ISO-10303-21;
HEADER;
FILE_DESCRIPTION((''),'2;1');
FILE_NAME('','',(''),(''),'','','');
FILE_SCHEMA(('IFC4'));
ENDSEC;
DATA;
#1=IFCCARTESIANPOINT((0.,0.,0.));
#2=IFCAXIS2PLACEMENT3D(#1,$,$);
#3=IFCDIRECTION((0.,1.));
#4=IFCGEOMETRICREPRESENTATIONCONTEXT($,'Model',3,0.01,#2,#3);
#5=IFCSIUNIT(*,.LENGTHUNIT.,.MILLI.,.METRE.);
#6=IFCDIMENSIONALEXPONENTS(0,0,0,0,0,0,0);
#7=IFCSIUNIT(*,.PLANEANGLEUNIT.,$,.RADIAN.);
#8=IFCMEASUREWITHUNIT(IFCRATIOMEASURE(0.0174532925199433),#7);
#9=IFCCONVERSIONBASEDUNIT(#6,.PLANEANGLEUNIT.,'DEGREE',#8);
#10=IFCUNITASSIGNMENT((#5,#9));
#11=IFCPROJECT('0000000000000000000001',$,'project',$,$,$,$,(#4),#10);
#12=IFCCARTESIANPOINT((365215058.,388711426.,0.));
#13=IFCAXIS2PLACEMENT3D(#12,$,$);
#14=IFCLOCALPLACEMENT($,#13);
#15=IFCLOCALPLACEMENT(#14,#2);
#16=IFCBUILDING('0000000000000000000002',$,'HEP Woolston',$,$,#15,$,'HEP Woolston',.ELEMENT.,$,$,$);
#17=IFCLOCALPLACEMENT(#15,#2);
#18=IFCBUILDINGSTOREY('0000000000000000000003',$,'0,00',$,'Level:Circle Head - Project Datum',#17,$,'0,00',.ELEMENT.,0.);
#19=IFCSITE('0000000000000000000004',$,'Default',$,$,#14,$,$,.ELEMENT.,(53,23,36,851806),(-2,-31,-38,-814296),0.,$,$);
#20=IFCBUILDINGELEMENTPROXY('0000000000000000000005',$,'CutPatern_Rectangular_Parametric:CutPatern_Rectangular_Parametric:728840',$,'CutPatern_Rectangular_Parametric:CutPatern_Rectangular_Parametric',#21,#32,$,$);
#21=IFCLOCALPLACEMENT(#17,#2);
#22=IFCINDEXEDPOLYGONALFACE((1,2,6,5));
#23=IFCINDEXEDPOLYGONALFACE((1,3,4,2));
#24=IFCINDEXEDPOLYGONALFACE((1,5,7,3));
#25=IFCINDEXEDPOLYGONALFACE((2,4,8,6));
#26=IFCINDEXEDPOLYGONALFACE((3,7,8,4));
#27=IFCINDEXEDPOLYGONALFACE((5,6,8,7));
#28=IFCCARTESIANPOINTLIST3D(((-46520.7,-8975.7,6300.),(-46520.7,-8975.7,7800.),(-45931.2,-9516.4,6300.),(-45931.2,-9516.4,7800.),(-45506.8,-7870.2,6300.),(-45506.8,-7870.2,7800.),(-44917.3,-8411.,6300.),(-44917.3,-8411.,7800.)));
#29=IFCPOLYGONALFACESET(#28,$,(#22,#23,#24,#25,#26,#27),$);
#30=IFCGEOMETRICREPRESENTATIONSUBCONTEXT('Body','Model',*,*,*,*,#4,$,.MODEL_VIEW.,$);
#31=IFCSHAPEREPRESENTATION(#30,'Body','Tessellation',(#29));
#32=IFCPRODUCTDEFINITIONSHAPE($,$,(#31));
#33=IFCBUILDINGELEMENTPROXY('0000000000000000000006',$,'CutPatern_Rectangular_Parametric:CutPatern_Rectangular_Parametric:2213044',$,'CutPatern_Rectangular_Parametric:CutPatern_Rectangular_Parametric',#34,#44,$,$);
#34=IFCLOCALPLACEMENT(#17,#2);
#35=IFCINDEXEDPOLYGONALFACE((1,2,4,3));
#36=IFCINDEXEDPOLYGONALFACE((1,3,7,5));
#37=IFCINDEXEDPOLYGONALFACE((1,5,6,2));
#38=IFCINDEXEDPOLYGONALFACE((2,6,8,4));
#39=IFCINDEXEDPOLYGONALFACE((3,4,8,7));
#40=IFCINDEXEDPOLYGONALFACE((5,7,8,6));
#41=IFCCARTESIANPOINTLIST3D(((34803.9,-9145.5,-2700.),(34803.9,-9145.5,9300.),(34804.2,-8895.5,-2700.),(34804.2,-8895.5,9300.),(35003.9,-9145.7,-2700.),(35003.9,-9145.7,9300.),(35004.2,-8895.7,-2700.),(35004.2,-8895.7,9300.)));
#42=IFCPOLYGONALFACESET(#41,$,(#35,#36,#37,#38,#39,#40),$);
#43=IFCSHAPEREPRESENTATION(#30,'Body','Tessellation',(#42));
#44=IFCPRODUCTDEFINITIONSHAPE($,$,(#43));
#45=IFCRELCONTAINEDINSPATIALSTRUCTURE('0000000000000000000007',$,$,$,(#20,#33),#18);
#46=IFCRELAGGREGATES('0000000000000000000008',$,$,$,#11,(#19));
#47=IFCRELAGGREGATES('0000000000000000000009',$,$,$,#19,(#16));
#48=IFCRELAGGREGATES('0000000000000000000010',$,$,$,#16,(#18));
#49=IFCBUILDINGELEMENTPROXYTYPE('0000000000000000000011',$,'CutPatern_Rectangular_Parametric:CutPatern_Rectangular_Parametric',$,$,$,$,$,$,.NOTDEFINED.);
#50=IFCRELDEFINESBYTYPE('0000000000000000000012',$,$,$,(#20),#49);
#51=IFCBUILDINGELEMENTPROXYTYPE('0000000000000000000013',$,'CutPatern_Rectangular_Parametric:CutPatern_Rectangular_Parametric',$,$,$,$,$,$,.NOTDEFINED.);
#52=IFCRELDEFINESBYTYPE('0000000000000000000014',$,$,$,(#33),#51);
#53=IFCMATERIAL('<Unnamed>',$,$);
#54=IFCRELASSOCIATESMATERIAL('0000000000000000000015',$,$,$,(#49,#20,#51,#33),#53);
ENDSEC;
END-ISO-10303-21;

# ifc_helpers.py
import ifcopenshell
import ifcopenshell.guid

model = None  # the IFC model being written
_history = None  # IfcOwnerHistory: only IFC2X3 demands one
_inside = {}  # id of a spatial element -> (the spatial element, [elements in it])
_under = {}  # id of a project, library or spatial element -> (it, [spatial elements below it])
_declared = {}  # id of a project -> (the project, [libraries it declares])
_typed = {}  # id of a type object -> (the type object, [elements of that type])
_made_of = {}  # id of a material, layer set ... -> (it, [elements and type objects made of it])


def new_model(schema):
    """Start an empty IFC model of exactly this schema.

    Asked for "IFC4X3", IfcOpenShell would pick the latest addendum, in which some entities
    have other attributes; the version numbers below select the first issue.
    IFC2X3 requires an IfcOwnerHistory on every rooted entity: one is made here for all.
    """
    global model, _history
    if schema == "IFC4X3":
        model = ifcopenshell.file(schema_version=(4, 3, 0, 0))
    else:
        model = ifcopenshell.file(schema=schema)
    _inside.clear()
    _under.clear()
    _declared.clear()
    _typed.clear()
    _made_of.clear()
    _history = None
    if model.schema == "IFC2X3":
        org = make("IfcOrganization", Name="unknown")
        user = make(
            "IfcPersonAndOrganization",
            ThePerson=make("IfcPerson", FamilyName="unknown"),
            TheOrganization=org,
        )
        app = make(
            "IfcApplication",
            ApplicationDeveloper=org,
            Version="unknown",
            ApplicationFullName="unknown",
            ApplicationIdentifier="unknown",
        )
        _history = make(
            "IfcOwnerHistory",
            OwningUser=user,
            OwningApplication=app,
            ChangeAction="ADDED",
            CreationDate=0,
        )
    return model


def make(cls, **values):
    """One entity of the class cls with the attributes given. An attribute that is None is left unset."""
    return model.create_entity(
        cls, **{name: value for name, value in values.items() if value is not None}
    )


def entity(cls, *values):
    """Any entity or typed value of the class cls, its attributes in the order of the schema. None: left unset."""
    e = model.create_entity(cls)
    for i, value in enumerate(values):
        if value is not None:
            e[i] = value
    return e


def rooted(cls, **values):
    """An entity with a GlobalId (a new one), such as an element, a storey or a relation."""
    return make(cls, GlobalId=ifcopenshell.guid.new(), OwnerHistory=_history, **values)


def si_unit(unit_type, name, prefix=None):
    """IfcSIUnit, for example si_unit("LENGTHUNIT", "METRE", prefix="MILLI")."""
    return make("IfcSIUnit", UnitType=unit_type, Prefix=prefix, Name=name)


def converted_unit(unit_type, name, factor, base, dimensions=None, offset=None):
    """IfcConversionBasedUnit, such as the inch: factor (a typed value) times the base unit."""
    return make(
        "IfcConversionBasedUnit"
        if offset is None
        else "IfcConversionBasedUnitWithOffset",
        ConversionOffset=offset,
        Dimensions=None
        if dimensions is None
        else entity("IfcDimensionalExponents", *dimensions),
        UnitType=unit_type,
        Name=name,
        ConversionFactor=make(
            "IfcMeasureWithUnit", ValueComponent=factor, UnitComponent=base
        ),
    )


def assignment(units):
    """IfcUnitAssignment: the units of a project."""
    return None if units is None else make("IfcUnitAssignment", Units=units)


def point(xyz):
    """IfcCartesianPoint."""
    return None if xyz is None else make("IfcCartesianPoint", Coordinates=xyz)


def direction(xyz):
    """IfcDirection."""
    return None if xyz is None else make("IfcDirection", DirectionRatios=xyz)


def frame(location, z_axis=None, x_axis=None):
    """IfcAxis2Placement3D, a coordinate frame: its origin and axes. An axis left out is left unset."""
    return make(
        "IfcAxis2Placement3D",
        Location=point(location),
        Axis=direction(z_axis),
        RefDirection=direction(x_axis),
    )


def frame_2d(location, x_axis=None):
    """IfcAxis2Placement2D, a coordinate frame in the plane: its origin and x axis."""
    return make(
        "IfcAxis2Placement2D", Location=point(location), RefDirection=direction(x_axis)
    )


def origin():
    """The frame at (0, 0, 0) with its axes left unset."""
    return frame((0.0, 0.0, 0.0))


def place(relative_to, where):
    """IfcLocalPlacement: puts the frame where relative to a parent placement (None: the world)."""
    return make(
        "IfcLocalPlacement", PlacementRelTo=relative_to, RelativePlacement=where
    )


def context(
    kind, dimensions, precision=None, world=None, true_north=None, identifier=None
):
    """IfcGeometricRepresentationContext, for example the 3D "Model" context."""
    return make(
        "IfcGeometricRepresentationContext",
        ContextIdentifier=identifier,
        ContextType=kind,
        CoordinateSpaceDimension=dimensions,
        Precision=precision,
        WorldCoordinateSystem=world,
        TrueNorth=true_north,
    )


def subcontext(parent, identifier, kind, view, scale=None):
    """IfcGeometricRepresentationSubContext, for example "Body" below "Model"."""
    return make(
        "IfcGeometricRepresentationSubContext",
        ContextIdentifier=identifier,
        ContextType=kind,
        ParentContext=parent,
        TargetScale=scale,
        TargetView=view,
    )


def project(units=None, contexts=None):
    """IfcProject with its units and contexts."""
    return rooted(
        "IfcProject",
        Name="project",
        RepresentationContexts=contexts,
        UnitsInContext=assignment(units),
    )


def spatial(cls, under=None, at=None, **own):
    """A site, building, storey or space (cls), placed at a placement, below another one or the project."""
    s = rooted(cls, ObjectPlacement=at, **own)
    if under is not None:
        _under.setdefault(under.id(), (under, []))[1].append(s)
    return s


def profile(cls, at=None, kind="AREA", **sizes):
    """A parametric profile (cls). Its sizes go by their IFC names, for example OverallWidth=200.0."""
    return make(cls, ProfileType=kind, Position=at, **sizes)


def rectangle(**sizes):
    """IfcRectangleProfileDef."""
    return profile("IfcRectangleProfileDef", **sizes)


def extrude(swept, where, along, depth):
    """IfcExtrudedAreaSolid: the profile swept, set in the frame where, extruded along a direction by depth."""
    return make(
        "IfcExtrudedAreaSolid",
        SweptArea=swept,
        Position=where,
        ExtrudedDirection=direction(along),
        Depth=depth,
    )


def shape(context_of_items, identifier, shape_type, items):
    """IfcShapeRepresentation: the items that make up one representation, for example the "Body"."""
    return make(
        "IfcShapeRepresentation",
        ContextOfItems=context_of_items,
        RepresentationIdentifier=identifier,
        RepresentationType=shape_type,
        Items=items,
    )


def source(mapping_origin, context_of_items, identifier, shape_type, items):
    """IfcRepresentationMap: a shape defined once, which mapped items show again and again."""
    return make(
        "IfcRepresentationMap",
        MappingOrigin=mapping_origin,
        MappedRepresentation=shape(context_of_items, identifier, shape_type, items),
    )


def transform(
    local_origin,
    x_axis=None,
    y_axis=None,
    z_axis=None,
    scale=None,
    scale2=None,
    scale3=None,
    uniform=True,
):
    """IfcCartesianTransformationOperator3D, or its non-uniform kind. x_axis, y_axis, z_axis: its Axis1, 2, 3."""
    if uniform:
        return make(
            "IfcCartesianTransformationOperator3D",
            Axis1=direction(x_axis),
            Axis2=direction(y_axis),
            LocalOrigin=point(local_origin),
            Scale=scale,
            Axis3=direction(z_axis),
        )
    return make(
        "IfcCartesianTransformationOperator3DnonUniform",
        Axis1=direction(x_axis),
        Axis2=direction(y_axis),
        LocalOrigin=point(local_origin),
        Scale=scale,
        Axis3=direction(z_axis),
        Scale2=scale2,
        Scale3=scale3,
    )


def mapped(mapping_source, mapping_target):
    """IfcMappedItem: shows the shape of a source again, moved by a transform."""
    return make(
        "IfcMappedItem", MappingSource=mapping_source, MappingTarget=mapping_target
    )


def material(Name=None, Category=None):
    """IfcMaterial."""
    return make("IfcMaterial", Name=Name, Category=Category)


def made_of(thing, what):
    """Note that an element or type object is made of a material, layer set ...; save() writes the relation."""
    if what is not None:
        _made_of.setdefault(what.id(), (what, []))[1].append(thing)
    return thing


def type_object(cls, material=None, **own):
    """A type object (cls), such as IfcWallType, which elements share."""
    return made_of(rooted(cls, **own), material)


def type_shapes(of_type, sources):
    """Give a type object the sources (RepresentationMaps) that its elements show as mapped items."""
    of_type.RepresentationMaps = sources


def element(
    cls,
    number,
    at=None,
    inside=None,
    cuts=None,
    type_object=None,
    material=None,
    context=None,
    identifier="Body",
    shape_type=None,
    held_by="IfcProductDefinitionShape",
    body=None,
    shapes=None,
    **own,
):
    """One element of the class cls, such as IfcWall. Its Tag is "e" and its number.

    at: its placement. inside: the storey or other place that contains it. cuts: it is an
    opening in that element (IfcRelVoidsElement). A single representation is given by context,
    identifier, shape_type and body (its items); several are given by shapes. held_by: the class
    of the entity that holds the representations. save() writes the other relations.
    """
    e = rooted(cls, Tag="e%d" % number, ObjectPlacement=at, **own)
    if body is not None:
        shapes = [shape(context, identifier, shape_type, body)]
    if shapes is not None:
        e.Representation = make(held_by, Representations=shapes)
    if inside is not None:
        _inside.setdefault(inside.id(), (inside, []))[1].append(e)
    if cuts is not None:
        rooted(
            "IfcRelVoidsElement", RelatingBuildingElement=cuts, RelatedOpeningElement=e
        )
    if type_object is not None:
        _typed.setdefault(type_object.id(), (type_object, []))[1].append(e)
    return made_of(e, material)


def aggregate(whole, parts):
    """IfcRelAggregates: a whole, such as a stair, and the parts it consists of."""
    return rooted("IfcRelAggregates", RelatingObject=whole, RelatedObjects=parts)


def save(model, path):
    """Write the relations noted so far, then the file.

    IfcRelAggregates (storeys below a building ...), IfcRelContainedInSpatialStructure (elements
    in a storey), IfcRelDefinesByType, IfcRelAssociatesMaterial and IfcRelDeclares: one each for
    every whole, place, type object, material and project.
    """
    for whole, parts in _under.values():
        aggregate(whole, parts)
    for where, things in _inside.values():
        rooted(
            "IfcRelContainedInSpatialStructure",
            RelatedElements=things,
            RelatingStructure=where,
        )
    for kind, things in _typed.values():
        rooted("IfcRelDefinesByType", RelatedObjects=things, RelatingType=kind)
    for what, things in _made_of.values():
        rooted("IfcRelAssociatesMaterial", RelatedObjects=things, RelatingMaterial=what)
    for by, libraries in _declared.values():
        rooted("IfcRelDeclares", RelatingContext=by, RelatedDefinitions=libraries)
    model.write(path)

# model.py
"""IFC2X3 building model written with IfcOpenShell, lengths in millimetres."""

from ifc_helpers import new_model, entity, si_unit, converted_unit, direction, frame, frame_2d, origin, place, context, subcontext, project, spatial, rectangle, extrude, source, transform, mapped, material, type_object, type_shapes, element, save


model = new_model("IFC2X3")

# Units and contexts
model_context = context("Model", 3, precision=0.01, world=origin(), true_north=direction((0.0, 1.0)))
body_context = subcontext(model_context, "Body", "Model", "MODEL_VIEW")
ifc_project = project(units=[si_unit("LENGTHUNIT", "METRE", prefix="MILLI"), converted_unit("PLANEANGLEUNIT", "DEGREE", entity("IfcRatioMeasure", 0.0174532925199433), si_unit("PLANEANGLEUNIT", "RADIAN"), dimensions=[0, 0, 0, 0, 0, 0, 0])], contexts=[model_context])

# Site, building, storey
site_placement = place(None, frame((365215058.0, 388711426.0, 0.0)))
site = spatial("IfcSite", under=ifc_project, at=site_placement, Name="Default", CompositionType="ELEMENT", RefLatitude=(53, 23, 36, 851806), RefLongitude=(-2, -31, -38, -814296), RefElevation=0.0)
building_placement = place(site_placement, origin())
building = spatial("IfcBuilding", under=site, at=building_placement, Name="HEP Woolston", LongName="HEP Woolston", CompositionType="ELEMENT")
storey_placement = place(building_placement, origin())
storey = spatial("IfcBuildingStorey", under=building, at=storey_placement, Name="0,00", ObjectType="Level:Circle Head - Project Datum", LongName="0,00", CompositionType="ELEMENT", Elevation=0.0)

# Building element proxies
ifc_material_1 = material(Name="<Unnamed>")
building_element_proxy_type_1 = type_object("IfcBuildingElementProxyType", Name="CutPatern_Rectangular_Parametric:CutPatern_Rectangular_Parametric", PredefinedType="NOTDEFINED", material=ifc_material_1)
shared_shape_1 = source(origin(), body_context, "Body", "SweptSolid", [
    extrude(rectangle(XDim=1500.0, YDim=800.0, at=frame_2d((0.0, 0.0), x_axis=(1.0, 0.0))), frame((-45719.0, -8693.3, 6300.0), z_axis=(0.0, 0.0, 1.0), x_axis=(-0.675928, -0.736968, 0.0)), (0.0, 0.0, 1.0), 1500.0),
])
type_shapes(building_element_proxy_type_1, [shared_shape_1])
proxy_1_placement = place(storey_placement, origin())
element("IfcBuildingElementProxy", 1, at=proxy_1_placement, inside=storey, type_object=building_element_proxy_type_1, material=ifc_material_1, Name="CutPatern_Rectangular_Parametric:CutPatern_Rectangular_Parametric:728840", ObjectType="CutPatern_Rectangular_Parametric:CutPatern_Rectangular_Parametric", context=body_context, shape_type="MappedRepresentation", body=[
    mapped(shared_shape_1, transform((0.0, 0.0, 0.0), scale=1.0)),
])
building_element_proxy_type_2 = type_object("IfcBuildingElementProxyType", Name="CutPatern_Rectangular_Parametric:CutPatern_Rectangular_Parametric", PredefinedType="NOTDEFINED", material=ifc_material_1)
shared_shape_2 = source(origin(), body_context, "Body", "SweptSolid", [
    extrude(rectangle(XDim=250.0, YDim=200.0, at=frame_2d((0.0, 0.0), x_axis=(1.0, 0.0))), frame((34904.1, -9020.6, -2700.0), z_axis=(0.0, 0.0, 1.0), x_axis=(-0.00098, -1.0, 0.0)), (0.0, 0.0, 1.0), 12000.0),
])
type_shapes(building_element_proxy_type_2, [shared_shape_2])
proxy_2_placement = place(storey_placement, origin())
element("IfcBuildingElementProxy", 2, at=proxy_2_placement, inside=storey, type_object=building_element_proxy_type_2, material=ifc_material_1, Name="CutPatern_Rectangular_Parametric:CutPatern_Rectangular_Parametric:2213044", ObjectType="CutPatern_Rectangular_Parametric:CutPatern_Rectangular_Parametric", context=body_context, shape_type="MappedRepresentation", body=[
    mapped(shared_shape_2, transform((0.0, 0.0, 0.0), scale=1.0)),
])

save(model, "model.ifc")
